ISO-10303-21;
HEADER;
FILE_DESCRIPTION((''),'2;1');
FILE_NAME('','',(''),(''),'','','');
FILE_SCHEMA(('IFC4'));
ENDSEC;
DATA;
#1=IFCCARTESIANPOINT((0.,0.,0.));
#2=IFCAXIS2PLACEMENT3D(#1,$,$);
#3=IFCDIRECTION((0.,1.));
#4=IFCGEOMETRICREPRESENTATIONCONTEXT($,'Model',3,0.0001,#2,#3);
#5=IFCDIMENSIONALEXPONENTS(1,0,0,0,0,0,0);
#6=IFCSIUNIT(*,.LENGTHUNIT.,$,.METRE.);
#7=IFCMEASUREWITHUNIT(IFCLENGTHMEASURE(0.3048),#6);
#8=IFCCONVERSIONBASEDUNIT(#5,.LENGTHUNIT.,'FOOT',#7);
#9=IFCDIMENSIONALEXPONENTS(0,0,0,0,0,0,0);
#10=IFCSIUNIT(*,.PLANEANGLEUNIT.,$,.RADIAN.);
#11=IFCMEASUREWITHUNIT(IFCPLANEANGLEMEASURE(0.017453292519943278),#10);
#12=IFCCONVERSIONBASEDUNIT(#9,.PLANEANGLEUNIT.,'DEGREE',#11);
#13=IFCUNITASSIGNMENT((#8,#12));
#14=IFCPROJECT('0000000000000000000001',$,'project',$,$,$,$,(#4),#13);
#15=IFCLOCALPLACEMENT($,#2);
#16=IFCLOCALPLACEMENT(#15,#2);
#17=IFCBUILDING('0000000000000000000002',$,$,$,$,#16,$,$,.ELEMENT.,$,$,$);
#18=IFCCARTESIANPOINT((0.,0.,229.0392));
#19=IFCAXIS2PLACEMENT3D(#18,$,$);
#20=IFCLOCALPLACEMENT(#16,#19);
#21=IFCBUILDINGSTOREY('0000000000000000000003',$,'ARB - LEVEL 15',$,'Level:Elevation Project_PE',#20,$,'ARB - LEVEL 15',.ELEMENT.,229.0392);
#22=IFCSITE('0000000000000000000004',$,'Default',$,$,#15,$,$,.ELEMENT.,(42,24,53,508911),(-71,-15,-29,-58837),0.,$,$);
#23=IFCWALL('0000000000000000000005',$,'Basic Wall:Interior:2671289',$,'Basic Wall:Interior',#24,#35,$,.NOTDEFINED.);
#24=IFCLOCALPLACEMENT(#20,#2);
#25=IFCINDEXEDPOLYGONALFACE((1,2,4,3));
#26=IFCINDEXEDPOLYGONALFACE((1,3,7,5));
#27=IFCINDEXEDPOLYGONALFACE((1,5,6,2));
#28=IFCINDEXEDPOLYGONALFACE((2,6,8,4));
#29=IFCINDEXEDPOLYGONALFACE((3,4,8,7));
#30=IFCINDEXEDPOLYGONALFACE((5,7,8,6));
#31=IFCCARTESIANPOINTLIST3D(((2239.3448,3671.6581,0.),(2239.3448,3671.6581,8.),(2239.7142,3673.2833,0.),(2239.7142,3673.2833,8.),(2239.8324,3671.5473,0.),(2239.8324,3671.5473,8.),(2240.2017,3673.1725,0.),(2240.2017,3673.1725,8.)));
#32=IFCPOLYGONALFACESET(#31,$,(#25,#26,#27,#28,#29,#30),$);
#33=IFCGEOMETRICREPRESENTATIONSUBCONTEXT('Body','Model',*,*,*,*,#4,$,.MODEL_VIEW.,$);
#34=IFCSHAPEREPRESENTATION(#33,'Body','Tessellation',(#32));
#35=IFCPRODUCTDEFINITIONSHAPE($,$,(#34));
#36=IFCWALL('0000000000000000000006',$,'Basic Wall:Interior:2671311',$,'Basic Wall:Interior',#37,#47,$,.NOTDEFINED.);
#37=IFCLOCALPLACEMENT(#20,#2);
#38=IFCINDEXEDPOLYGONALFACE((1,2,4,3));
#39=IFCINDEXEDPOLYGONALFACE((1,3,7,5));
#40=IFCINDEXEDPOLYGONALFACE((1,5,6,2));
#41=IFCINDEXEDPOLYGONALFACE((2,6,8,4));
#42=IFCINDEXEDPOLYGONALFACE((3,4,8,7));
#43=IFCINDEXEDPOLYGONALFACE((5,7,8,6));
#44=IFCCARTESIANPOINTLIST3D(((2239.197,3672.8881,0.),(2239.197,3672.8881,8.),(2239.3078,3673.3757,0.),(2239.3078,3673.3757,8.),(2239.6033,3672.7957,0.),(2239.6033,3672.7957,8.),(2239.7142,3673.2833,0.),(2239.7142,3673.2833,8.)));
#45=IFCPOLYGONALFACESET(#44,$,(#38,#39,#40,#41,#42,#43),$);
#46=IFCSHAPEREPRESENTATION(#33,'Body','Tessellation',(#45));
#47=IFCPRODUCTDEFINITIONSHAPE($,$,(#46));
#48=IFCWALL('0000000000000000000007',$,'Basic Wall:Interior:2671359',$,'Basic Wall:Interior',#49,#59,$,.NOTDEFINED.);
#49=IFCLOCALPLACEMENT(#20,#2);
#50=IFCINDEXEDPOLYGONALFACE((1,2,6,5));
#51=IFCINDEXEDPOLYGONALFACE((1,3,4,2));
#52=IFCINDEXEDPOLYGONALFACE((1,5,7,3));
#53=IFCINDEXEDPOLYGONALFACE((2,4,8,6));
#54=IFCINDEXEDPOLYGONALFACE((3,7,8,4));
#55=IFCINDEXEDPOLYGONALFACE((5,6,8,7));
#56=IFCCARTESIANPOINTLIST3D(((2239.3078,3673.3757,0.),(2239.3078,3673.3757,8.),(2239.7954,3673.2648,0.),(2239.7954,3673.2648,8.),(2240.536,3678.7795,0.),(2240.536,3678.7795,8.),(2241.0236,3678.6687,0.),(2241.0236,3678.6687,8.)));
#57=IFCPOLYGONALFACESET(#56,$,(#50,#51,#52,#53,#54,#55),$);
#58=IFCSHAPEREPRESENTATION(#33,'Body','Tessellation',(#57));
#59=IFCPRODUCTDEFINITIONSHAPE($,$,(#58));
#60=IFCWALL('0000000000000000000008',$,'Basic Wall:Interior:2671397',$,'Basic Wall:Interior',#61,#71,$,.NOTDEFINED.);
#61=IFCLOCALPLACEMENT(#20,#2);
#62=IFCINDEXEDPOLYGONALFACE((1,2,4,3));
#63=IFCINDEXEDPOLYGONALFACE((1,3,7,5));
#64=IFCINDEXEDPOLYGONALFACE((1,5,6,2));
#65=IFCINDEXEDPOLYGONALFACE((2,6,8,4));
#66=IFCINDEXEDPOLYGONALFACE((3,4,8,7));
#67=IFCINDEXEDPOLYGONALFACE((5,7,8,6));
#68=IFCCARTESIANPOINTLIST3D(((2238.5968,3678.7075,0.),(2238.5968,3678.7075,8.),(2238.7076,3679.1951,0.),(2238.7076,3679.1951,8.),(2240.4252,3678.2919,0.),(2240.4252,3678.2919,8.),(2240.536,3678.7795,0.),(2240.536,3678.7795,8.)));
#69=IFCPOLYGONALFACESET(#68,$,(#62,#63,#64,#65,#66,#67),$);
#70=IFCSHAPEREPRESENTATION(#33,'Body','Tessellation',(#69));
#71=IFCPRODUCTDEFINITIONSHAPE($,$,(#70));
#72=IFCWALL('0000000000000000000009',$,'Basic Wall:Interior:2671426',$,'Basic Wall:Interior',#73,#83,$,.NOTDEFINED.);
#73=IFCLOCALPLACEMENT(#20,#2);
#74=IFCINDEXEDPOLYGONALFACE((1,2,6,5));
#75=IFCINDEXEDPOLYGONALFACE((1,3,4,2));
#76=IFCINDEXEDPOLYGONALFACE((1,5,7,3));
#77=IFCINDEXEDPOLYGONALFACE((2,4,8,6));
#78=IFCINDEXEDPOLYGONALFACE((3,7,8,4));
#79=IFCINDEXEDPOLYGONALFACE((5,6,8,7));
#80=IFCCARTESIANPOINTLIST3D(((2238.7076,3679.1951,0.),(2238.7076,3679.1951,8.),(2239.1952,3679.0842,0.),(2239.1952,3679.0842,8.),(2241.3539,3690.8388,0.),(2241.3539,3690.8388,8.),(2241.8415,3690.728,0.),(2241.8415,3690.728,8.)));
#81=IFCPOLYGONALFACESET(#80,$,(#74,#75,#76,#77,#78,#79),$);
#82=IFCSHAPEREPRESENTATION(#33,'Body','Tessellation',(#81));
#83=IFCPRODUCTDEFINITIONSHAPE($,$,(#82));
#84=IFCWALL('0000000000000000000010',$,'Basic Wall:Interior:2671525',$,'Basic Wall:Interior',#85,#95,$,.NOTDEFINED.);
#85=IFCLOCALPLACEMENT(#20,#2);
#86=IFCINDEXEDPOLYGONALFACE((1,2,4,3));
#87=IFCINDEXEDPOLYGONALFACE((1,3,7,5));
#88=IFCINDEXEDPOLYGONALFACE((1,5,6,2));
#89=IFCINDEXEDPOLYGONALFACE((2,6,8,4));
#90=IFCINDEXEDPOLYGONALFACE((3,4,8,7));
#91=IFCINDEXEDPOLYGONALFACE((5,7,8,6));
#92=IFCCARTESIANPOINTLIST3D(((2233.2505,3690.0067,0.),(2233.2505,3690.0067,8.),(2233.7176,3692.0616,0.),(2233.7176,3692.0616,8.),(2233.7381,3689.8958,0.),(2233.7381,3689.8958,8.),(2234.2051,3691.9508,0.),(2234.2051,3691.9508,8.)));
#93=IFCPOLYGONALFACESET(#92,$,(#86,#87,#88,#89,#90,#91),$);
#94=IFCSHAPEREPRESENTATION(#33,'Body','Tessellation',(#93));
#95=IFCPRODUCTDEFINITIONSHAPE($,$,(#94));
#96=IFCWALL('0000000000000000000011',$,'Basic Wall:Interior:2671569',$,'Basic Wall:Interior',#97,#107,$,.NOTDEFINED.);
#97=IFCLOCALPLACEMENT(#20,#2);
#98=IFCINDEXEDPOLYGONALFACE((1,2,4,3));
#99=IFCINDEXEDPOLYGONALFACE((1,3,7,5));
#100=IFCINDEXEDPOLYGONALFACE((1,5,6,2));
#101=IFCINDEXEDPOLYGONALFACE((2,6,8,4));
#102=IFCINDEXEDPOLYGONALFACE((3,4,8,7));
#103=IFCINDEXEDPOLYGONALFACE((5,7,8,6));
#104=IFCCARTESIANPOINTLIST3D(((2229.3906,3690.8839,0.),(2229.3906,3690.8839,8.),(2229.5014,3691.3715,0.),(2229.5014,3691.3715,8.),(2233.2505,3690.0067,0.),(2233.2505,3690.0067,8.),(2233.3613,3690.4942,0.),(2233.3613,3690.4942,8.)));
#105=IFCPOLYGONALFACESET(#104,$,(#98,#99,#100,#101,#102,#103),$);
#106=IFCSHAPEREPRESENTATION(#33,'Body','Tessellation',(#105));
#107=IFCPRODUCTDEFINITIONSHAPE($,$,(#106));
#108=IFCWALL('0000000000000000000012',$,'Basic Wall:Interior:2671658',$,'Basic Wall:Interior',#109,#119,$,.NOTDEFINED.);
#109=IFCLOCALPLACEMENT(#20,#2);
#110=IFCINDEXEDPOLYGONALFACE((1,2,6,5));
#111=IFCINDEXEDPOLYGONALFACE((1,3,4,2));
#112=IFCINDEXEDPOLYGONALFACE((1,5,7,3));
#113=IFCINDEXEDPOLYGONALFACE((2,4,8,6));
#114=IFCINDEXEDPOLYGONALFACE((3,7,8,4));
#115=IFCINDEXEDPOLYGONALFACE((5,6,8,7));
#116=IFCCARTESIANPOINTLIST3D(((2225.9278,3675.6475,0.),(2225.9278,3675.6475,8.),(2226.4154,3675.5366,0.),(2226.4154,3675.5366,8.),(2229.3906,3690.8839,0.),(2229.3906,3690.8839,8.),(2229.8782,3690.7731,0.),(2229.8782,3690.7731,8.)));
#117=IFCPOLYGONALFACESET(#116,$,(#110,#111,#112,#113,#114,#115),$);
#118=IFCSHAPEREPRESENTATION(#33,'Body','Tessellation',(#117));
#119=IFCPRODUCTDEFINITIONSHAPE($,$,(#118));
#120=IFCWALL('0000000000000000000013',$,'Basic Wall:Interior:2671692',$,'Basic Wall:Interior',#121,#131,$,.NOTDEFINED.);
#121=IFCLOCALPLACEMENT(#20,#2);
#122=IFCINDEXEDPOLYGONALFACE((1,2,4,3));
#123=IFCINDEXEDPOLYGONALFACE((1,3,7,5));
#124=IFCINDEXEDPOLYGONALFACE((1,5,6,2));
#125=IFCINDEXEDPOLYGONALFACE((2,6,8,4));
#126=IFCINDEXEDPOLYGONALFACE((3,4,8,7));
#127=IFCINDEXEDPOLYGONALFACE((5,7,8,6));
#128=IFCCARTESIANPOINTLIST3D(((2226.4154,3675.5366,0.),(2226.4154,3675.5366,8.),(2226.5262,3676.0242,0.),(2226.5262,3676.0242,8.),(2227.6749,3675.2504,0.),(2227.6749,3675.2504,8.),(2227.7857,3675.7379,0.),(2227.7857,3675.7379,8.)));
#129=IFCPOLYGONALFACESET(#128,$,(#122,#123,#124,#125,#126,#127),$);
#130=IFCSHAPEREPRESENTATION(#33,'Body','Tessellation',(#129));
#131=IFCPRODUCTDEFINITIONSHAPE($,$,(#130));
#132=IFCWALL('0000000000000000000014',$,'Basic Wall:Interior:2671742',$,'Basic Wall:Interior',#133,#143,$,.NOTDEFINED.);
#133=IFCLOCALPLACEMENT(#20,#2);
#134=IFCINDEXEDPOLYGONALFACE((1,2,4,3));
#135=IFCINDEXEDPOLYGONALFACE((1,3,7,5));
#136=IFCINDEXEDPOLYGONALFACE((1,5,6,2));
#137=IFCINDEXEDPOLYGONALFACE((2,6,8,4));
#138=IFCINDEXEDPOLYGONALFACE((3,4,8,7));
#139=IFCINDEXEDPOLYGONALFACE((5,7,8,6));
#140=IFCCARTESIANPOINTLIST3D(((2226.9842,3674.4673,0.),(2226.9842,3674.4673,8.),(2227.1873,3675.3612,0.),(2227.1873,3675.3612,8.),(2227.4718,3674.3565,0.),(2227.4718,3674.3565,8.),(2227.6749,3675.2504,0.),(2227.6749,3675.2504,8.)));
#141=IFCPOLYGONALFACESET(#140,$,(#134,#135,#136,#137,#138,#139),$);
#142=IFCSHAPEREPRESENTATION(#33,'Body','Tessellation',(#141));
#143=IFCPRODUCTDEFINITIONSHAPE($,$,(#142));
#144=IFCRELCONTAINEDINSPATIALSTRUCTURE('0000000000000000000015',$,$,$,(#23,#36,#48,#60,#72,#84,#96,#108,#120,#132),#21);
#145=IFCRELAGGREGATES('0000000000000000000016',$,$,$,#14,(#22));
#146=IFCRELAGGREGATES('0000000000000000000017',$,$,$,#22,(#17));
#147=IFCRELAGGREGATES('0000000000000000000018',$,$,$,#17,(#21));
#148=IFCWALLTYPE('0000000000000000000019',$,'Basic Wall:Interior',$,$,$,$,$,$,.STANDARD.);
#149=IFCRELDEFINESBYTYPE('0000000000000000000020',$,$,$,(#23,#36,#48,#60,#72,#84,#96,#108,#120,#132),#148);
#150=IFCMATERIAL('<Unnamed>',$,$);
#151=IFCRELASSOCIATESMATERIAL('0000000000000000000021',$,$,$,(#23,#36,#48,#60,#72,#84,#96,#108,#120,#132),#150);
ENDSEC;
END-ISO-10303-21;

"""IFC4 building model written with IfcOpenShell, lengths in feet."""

from ifc_helpers import new_model, entity, si_unit, converted_unit, direction, frame, origin, place, context, subcontext, project, spatial, indexed_curve, outline, extrude, material, type_object, element, save


model = new_model("IFC4")

# Units and contexts
model_context = context("Model", 3, precision=0.0001, world=origin(), true_north=direction((0.0, 1.0)))
body_context = subcontext(model_context, "Body", "Model", "MODEL_VIEW")
ifc_project = project(units=[converted_unit("LENGTHUNIT", "FOOT", entity("IfcLengthMeasure", 0.3048), si_unit("LENGTHUNIT", "METRE"), dimensions=[1, 0, 0, 0, 0, 0, 0]), converted_unit("PLANEANGLEUNIT", "DEGREE", entity("IfcPlaneAngleMeasure", 0.017453292519943278), si_unit("PLANEANGLEUNIT", "RADIAN"), dimensions=[0, 0, 0, 0, 0, 0, 0])], contexts=[model_context])

# Site, building, storey
site_placement = place(None, origin())
site = spatial("IfcSite", under=ifc_project, at=site_placement, Name="Default", CompositionType="ELEMENT", RefLatitude=(42, 24, 53, 508911), RefLongitude=(-71, -15, -29, -58837), RefElevation=0.0)
building_placement = place(site_placement, origin())
building = spatial("IfcBuilding", under=site, at=building_placement, CompositionType="ELEMENT")
storey_placement = place(building_placement, frame((0.0, 0.0, 229.0392)))
storey = spatial("IfcBuildingStorey", under=building, at=storey_placement, Name="ARB - LEVEL 15", ObjectType="Level:Elevation Project_PE", LongName="ARB - LEVEL 15", CompositionType="ELEMENT", Elevation=229.0392)

# Walls
ifc_material_1 = material(Name="<Unnamed>")
wall_type = type_object("IfcWallType", Name="Basic Wall:Interior", PredefinedType="STANDARD")
wall_1_placement = place(storey_placement, frame((2239.5886, 3671.6027, 0.0), z_axis=(0.0, 0.0, 1.0), x_axis=(0.221622, 0.975133, 0.0)))
element("IfcWall", 1, at=wall_1_placement, inside=storey, type_object=wall_type, material=ifc_material_1, Name="Basic Wall:Interior:2671289", ObjectType="Basic Wall:Interior", PredefinedType="NOTDEFINED", context=body_context, shape_type="SweptSolid", body=[
    extrude(outline(indexed_curve([(1.6667, 0.25), (0.0, 0.25), (0.0, -0.25), (1.6667, -0.25), (1.6667, 0.25)], self_intersect=False)), origin(), (0.0, 0.0, 1.0), 8.0),
])
wall_2_placement = place(storey_placement, frame((2239.6587, 3673.0395, 0.0), z_axis=(0.0, 0.0, 1.0), x_axis=(-0.975133, 0.221622, 0.0)))
element("IfcWall", 2, at=wall_2_placement, inside=storey, type_object=wall_type, material=ifc_material_1, Name="Basic Wall:Interior:2671311", ObjectType="Basic Wall:Interior", PredefinedType="NOTDEFINED", context=body_context, shape_type="SweptSolid", body=[
    extrude(outline(indexed_curve([(0.4167, 0.25), (0.0, 0.25), (0.0, -0.25), (0.4167, -0.25), (0.4167, 0.25)], self_intersect=False)), origin(), (0.0, 0.0, 1.0), 8.0),
])
wall_3_placement = place(storey_placement, frame((2239.5516, 3673.3202, 0.0), z_axis=(0.0, 0.0, 1.0), x_axis=(0.221622, 0.975133, 0.0)))
element("IfcWall", 3, at=wall_3_placement, inside=storey, type_object=wall_type, material=ifc_material_1, Name="Basic Wall:Interior:2671359", ObjectType="Basic Wall:Interior", PredefinedType="NOTDEFINED", context=body_context, shape_type="SweptSolid", body=[
    extrude(outline(indexed_curve([(5.5417, 0.25), (0.0, 0.25), (0.0, -0.25), (5.5417, -0.25), (5.5417, 0.25)], self_intersect=False)), origin(), (0.0, 0.0, 1.0), 8.0),
])
wall_4_placement = place(storey_placement, frame((2240.4806, 3678.5357, 0.0), z_axis=(0.0, 0.0, 1.0), x_axis=(-0.975133, 0.221622, 0.0)))
element("IfcWall", 4, at=wall_4_placement, inside=storey, type_object=wall_type, material=ifc_material_1, Name="Basic Wall:Interior:2671397", ObjectType="Basic Wall:Interior", PredefinedType="NOTDEFINED", context=body_context, shape_type="SweptSolid", body=[
    extrude(outline(indexed_curve([(1.875, 0.25), (0.0, 0.25), (0.0, -0.25), (1.875, -0.25), (1.875, 0.25)], self_intersect=False)), origin(), (0.0, 0.0, 1.0), 8.0),
])
wall_5_placement = place(storey_placement, frame((2238.9514, 3679.1396, 0.0), z_axis=(0.0, 0.0, 1.0), x_axis=(0.221622, 0.975133, 0.0)))
element("IfcWall", 5, at=wall_5_placement, inside=storey, type_object=wall_type, material=ifc_material_1, Name="Basic Wall:Interior:2671426", ObjectType="Basic Wall:Interior", PredefinedType="NOTDEFINED", context=body_context, shape_type="SweptSolid", body=[
    extrude(outline(indexed_curve([(11.9407, 0.25), (0.0, 0.25), (0.0, -0.25), (11.9407, -0.25), (11.9407, 0.25)], self_intersect=False)), origin(), (0.0, 0.0, 1.0), 8.0),
])
wall_6_placement = place(storey_placement, frame((2233.9613, 3692.0062, 0.0), z_axis=(0.0, 0.0, 1.0), x_axis=(-0.221622, -0.975133, 0.0)))
element("IfcWall", 6, at=wall_6_placement, inside=storey, type_object=wall_type, material=ifc_material_1, Name="Basic Wall:Interior:2671525", ObjectType="Basic Wall:Interior", PredefinedType="NOTDEFINED", context=body_context, shape_type="SweptSolid", body=[
    extrude(outline(indexed_curve([(2.1073, 0.25), (0.0, 0.25), (0.0, -0.25), (2.1073, -0.25), (2.1073, 0.25)], self_intersect=False)), origin(), (0.0, 0.0, 1.0), 8.0),
])
wall_7_placement = place(storey_placement, frame((2233.3059, 3690.2504, 0.0), z_axis=(0.0, 0.0, 1.0), x_axis=(-0.975133, 0.221622, 0.0)))
element("IfcWall", 7, at=wall_7_placement, inside=storey, type_object=wall_type, material=ifc_material_1, Name="Basic Wall:Interior:2671569", ObjectType="Basic Wall:Interior", PredefinedType="NOTDEFINED", context=body_context, shape_type="SweptSolid", body=[
    extrude(outline(indexed_curve([(3.9583, 0.25), (0.0, 0.25), (0.0, -0.25), (3.9583, -0.25), (3.9583, 0.25)], self_intersect=False)), origin(), (0.0, 0.0, 1.0), 8.0),
])
wall_8_placement = place(storey_placement, frame((2229.6344, 3690.8285, 0.0), z_axis=(0.0, 0.0, 1.0), x_axis=(-0.221622, -0.975133, 0.0)))
element("IfcWall", 8, at=wall_8_placement, inside=storey, type_object=wall_type, material=ifc_material_1, Name="Basic Wall:Interior:2671658", ObjectType="Basic Wall:Interior", PredefinedType="NOTDEFINED", context=body_context, shape_type="SweptSolid", body=[
    extrude(outline(indexed_curve([(15.625, 0.25), (0.0, 0.25), (0.0, -0.25), (15.625, -0.25), (15.625, 0.25)], self_intersect=False)), origin(), (0.0, 0.0, 1.0), 8.0),
])
wall_9_placement = place(storey_placement, frame((2226.4708, 3675.7804, 0.0), z_axis=(0.0, 0.0, 1.0), x_axis=(0.975133, -0.221622, 0.0)))
element("IfcWall", 9, at=wall_9_placement, inside=storey, type_object=wall_type, material=ifc_material_1, Name="Basic Wall:Interior:2671692", ObjectType="Basic Wall:Interior", PredefinedType="NOTDEFINED", context=body_context, shape_type="SweptSolid", body=[
    extrude(outline(indexed_curve([(1.2917, 0.25), (0.0, 0.25), (0.0, -0.25), (1.2917, -0.25), (1.2917, 0.25)], self_intersect=False)), origin(), (0.0, 0.0, 1.0), 8.0),
])
wall_10_placement = place(storey_placement, frame((2227.4311, 3675.3058, 0.0), z_axis=(0.0, 0.0, 1.0), x_axis=(-0.221622, -0.975133, 0.0)))
element("IfcWall", 10, at=wall_10_placement, inside=storey, type_object=wall_type, material=ifc_material_1, Name="Basic Wall:Interior:2671742", ObjectType="Basic Wall:Interior", PredefinedType="NOTDEFINED", context=body_context, shape_type="SweptSolid", body=[
    extrude(outline(indexed_curve([(0.9167, 0.25), (0.0, 0.25), (0.0, -0.25), (0.9167, -0.25), (0.9167, 0.25)], self_intersect=False)), origin(), (0.0, 0.0, 1.0), 8.0),
])

save(model, "model.ifc")
